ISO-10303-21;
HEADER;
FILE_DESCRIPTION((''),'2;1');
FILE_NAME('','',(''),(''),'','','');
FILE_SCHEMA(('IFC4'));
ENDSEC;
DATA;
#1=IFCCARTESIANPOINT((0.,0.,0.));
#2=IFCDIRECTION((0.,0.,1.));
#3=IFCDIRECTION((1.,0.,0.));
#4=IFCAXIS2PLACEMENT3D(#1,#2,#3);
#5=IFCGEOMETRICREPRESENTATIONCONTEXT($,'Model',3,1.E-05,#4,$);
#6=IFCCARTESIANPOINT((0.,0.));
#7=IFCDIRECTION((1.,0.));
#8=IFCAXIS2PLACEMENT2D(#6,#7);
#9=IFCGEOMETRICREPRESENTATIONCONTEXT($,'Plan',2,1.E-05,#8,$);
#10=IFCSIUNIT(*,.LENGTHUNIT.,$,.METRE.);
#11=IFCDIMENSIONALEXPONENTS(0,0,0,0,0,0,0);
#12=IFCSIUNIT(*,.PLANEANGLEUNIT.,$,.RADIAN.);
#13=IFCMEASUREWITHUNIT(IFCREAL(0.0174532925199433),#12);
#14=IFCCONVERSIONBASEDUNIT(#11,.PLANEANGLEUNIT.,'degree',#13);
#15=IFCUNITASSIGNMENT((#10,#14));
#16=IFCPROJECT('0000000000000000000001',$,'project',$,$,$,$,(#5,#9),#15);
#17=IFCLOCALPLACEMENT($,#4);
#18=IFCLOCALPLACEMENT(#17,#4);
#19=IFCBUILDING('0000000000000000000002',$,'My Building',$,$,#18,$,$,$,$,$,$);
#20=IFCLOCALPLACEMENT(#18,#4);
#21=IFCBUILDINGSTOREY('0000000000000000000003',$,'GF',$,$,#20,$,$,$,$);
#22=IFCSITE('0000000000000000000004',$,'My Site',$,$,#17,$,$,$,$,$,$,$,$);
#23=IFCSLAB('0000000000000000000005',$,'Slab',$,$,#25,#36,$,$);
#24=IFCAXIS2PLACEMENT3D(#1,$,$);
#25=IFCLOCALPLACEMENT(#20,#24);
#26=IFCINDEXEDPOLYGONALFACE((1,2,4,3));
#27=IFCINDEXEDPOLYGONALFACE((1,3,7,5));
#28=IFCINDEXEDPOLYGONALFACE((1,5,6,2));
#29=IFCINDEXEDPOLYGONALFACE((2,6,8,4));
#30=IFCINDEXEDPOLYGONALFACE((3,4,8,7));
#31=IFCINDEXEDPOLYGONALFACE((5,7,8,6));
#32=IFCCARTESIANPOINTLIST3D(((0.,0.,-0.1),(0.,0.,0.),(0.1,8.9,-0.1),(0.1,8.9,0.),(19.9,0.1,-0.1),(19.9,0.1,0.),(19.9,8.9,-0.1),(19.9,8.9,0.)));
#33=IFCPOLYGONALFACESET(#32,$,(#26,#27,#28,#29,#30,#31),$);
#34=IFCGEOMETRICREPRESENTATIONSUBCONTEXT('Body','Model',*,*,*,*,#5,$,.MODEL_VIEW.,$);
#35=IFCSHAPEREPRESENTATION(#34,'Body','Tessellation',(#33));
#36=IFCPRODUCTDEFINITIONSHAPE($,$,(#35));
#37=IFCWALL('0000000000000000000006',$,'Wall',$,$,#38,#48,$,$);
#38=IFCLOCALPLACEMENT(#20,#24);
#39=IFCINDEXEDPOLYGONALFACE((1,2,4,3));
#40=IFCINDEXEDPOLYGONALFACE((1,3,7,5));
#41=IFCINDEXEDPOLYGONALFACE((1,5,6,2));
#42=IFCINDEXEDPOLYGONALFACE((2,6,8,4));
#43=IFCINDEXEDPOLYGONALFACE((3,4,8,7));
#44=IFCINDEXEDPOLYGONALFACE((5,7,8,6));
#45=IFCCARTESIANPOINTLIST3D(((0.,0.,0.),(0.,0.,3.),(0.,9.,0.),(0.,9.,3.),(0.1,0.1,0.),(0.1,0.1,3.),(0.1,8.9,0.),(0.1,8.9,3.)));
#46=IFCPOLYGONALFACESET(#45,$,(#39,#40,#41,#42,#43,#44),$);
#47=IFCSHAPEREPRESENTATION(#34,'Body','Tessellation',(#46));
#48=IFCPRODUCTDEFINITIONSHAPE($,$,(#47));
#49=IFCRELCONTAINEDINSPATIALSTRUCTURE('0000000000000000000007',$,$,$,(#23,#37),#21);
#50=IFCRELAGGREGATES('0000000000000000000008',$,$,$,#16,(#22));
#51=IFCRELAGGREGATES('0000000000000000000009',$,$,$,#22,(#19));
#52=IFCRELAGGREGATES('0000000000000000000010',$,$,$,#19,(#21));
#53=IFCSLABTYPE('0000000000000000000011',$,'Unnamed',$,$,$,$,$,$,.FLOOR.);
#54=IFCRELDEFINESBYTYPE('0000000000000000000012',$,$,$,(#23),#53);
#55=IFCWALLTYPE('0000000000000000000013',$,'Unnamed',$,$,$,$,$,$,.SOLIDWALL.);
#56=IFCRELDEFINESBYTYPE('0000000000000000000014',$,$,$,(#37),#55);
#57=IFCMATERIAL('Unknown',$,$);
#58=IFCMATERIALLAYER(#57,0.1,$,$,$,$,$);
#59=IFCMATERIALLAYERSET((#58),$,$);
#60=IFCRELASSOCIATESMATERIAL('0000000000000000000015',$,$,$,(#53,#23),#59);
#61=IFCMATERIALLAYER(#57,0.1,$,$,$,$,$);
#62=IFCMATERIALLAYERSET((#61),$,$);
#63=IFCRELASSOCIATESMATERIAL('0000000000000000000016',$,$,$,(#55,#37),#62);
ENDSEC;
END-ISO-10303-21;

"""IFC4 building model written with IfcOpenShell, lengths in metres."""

from ifc_helpers import new_model, entity, si_unit, converted_unit, frame, origin_with_axes, origin_2d_with_axis, place, context, subcontext, project, spatial, line, indexed_curve, outline, extrude, material, layer, layer_set, layer_usage, type_object, element, save


model = new_model("IFC4")

# Units and contexts
model_context = context("Model", 3, precision=1e-05, world=origin_with_axes())
plan_context = context("Plan", 2, precision=1e-05, world=origin_2d_with_axis())
body_context_1 = subcontext(model_context, "Body", "Model", "MODEL_VIEW")
ifc_project = project(units=[si_unit("LENGTHUNIT", "METRE"), converted_unit("PLANEANGLEUNIT", "degree", entity("IfcReal", 0.0174532925199433), si_unit("PLANEANGLEUNIT", "RADIAN"), dimensions=[0, 0, 0, 0, 0, 0, 0])], contexts=[model_context, plan_context])

# Site, building, storey
site_placement = place(None, origin_with_axes())
site = spatial("IfcSite", under=ifc_project, at=site_placement, Name="My Site")
building_placement = place(site_placement, origin_with_axes())
building = spatial("IfcBuilding", under=site, at=building_placement, Name="My Building")
storey_placement = place(building_placement, origin_with_axes())
storey = spatial("IfcBuildingStorey", under=building, at=storey_placement, Name="GF")

# Slab
ifc_material = material(Name="Unknown")
ifc_layer_1 = layer(ifc_material, 0.1)
ifc_layer_set_1 = layer_set([ifc_layer_1])
ifc_layer_usage_1 = layer_usage(ifc_layer_set_1, "AXIS3", "POSITIVE", -0.1)
slab_type = type_object("IfcSlabType", Name="Unnamed", PredefinedType="FLOOR", material=ifc_layer_set_1)
slab_1_placement = place(storey_placement, frame((0.1, 8.9, 0.0), z_axis=(0.0, 0.0, 1.0), x_axis=(1.0, 0.0, 0.0)))
element("IfcSlab", 1, at=slab_1_placement, inside=storey, type_object=slab_type, material=ifc_layer_usage_1, Name="Slab", context=body_context_1, shape_type="SweptSolid", body=[
    extrude(outline(indexed_curve([(0.0, 0.0), (19.8, 0.0), (19.8, -8.8), (-0.1, -8.9), (0.0, 0.0)])), frame((0.0, 0.0, -0.1), z_axis=(0.0, 0.0, 1.0), x_axis=(1.0, 0.0, 0.0)), (0.0, 0.0, 1.0), 0.1),
])

# Shared definitions
ifc_layer_2 = layer(ifc_material, 0.1)
ifc_layer_set_2 = layer_set([ifc_layer_2])
wall_type = type_object("IfcWallType", Name="Unnamed", PredefinedType="SOLIDWALL", material=ifc_layer_set_2)

# Wall
ifc_layer_usage_2 = layer_usage(ifc_layer_set_2, "AXIS2", "POSITIVE", 0.0)
wall_1_placement = place(storey_placement, frame((0.0, 9.0, 0.0), z_axis=(0.0, 0.0, 1.0), x_axis=(0.0, -1.0, 0.0)))
element("IfcWall", 2, at=wall_1_placement, inside=storey, type_object=wall_type, material=ifc_layer_usage_2, Name="Wall", context=body_context_1, shape_type="SweptSolid", body=[
    extrude(outline(indexed_curve([(0.0, 0.0), (0.1, 0.1), (8.9, 0.1), (9.0, 0.0)], segments=[line(1, 2, 3, 4, 1)])), origin_with_axes(), (0.0, 0.0, 1.0), 3.0),
])

save(model, "model.ifc")
